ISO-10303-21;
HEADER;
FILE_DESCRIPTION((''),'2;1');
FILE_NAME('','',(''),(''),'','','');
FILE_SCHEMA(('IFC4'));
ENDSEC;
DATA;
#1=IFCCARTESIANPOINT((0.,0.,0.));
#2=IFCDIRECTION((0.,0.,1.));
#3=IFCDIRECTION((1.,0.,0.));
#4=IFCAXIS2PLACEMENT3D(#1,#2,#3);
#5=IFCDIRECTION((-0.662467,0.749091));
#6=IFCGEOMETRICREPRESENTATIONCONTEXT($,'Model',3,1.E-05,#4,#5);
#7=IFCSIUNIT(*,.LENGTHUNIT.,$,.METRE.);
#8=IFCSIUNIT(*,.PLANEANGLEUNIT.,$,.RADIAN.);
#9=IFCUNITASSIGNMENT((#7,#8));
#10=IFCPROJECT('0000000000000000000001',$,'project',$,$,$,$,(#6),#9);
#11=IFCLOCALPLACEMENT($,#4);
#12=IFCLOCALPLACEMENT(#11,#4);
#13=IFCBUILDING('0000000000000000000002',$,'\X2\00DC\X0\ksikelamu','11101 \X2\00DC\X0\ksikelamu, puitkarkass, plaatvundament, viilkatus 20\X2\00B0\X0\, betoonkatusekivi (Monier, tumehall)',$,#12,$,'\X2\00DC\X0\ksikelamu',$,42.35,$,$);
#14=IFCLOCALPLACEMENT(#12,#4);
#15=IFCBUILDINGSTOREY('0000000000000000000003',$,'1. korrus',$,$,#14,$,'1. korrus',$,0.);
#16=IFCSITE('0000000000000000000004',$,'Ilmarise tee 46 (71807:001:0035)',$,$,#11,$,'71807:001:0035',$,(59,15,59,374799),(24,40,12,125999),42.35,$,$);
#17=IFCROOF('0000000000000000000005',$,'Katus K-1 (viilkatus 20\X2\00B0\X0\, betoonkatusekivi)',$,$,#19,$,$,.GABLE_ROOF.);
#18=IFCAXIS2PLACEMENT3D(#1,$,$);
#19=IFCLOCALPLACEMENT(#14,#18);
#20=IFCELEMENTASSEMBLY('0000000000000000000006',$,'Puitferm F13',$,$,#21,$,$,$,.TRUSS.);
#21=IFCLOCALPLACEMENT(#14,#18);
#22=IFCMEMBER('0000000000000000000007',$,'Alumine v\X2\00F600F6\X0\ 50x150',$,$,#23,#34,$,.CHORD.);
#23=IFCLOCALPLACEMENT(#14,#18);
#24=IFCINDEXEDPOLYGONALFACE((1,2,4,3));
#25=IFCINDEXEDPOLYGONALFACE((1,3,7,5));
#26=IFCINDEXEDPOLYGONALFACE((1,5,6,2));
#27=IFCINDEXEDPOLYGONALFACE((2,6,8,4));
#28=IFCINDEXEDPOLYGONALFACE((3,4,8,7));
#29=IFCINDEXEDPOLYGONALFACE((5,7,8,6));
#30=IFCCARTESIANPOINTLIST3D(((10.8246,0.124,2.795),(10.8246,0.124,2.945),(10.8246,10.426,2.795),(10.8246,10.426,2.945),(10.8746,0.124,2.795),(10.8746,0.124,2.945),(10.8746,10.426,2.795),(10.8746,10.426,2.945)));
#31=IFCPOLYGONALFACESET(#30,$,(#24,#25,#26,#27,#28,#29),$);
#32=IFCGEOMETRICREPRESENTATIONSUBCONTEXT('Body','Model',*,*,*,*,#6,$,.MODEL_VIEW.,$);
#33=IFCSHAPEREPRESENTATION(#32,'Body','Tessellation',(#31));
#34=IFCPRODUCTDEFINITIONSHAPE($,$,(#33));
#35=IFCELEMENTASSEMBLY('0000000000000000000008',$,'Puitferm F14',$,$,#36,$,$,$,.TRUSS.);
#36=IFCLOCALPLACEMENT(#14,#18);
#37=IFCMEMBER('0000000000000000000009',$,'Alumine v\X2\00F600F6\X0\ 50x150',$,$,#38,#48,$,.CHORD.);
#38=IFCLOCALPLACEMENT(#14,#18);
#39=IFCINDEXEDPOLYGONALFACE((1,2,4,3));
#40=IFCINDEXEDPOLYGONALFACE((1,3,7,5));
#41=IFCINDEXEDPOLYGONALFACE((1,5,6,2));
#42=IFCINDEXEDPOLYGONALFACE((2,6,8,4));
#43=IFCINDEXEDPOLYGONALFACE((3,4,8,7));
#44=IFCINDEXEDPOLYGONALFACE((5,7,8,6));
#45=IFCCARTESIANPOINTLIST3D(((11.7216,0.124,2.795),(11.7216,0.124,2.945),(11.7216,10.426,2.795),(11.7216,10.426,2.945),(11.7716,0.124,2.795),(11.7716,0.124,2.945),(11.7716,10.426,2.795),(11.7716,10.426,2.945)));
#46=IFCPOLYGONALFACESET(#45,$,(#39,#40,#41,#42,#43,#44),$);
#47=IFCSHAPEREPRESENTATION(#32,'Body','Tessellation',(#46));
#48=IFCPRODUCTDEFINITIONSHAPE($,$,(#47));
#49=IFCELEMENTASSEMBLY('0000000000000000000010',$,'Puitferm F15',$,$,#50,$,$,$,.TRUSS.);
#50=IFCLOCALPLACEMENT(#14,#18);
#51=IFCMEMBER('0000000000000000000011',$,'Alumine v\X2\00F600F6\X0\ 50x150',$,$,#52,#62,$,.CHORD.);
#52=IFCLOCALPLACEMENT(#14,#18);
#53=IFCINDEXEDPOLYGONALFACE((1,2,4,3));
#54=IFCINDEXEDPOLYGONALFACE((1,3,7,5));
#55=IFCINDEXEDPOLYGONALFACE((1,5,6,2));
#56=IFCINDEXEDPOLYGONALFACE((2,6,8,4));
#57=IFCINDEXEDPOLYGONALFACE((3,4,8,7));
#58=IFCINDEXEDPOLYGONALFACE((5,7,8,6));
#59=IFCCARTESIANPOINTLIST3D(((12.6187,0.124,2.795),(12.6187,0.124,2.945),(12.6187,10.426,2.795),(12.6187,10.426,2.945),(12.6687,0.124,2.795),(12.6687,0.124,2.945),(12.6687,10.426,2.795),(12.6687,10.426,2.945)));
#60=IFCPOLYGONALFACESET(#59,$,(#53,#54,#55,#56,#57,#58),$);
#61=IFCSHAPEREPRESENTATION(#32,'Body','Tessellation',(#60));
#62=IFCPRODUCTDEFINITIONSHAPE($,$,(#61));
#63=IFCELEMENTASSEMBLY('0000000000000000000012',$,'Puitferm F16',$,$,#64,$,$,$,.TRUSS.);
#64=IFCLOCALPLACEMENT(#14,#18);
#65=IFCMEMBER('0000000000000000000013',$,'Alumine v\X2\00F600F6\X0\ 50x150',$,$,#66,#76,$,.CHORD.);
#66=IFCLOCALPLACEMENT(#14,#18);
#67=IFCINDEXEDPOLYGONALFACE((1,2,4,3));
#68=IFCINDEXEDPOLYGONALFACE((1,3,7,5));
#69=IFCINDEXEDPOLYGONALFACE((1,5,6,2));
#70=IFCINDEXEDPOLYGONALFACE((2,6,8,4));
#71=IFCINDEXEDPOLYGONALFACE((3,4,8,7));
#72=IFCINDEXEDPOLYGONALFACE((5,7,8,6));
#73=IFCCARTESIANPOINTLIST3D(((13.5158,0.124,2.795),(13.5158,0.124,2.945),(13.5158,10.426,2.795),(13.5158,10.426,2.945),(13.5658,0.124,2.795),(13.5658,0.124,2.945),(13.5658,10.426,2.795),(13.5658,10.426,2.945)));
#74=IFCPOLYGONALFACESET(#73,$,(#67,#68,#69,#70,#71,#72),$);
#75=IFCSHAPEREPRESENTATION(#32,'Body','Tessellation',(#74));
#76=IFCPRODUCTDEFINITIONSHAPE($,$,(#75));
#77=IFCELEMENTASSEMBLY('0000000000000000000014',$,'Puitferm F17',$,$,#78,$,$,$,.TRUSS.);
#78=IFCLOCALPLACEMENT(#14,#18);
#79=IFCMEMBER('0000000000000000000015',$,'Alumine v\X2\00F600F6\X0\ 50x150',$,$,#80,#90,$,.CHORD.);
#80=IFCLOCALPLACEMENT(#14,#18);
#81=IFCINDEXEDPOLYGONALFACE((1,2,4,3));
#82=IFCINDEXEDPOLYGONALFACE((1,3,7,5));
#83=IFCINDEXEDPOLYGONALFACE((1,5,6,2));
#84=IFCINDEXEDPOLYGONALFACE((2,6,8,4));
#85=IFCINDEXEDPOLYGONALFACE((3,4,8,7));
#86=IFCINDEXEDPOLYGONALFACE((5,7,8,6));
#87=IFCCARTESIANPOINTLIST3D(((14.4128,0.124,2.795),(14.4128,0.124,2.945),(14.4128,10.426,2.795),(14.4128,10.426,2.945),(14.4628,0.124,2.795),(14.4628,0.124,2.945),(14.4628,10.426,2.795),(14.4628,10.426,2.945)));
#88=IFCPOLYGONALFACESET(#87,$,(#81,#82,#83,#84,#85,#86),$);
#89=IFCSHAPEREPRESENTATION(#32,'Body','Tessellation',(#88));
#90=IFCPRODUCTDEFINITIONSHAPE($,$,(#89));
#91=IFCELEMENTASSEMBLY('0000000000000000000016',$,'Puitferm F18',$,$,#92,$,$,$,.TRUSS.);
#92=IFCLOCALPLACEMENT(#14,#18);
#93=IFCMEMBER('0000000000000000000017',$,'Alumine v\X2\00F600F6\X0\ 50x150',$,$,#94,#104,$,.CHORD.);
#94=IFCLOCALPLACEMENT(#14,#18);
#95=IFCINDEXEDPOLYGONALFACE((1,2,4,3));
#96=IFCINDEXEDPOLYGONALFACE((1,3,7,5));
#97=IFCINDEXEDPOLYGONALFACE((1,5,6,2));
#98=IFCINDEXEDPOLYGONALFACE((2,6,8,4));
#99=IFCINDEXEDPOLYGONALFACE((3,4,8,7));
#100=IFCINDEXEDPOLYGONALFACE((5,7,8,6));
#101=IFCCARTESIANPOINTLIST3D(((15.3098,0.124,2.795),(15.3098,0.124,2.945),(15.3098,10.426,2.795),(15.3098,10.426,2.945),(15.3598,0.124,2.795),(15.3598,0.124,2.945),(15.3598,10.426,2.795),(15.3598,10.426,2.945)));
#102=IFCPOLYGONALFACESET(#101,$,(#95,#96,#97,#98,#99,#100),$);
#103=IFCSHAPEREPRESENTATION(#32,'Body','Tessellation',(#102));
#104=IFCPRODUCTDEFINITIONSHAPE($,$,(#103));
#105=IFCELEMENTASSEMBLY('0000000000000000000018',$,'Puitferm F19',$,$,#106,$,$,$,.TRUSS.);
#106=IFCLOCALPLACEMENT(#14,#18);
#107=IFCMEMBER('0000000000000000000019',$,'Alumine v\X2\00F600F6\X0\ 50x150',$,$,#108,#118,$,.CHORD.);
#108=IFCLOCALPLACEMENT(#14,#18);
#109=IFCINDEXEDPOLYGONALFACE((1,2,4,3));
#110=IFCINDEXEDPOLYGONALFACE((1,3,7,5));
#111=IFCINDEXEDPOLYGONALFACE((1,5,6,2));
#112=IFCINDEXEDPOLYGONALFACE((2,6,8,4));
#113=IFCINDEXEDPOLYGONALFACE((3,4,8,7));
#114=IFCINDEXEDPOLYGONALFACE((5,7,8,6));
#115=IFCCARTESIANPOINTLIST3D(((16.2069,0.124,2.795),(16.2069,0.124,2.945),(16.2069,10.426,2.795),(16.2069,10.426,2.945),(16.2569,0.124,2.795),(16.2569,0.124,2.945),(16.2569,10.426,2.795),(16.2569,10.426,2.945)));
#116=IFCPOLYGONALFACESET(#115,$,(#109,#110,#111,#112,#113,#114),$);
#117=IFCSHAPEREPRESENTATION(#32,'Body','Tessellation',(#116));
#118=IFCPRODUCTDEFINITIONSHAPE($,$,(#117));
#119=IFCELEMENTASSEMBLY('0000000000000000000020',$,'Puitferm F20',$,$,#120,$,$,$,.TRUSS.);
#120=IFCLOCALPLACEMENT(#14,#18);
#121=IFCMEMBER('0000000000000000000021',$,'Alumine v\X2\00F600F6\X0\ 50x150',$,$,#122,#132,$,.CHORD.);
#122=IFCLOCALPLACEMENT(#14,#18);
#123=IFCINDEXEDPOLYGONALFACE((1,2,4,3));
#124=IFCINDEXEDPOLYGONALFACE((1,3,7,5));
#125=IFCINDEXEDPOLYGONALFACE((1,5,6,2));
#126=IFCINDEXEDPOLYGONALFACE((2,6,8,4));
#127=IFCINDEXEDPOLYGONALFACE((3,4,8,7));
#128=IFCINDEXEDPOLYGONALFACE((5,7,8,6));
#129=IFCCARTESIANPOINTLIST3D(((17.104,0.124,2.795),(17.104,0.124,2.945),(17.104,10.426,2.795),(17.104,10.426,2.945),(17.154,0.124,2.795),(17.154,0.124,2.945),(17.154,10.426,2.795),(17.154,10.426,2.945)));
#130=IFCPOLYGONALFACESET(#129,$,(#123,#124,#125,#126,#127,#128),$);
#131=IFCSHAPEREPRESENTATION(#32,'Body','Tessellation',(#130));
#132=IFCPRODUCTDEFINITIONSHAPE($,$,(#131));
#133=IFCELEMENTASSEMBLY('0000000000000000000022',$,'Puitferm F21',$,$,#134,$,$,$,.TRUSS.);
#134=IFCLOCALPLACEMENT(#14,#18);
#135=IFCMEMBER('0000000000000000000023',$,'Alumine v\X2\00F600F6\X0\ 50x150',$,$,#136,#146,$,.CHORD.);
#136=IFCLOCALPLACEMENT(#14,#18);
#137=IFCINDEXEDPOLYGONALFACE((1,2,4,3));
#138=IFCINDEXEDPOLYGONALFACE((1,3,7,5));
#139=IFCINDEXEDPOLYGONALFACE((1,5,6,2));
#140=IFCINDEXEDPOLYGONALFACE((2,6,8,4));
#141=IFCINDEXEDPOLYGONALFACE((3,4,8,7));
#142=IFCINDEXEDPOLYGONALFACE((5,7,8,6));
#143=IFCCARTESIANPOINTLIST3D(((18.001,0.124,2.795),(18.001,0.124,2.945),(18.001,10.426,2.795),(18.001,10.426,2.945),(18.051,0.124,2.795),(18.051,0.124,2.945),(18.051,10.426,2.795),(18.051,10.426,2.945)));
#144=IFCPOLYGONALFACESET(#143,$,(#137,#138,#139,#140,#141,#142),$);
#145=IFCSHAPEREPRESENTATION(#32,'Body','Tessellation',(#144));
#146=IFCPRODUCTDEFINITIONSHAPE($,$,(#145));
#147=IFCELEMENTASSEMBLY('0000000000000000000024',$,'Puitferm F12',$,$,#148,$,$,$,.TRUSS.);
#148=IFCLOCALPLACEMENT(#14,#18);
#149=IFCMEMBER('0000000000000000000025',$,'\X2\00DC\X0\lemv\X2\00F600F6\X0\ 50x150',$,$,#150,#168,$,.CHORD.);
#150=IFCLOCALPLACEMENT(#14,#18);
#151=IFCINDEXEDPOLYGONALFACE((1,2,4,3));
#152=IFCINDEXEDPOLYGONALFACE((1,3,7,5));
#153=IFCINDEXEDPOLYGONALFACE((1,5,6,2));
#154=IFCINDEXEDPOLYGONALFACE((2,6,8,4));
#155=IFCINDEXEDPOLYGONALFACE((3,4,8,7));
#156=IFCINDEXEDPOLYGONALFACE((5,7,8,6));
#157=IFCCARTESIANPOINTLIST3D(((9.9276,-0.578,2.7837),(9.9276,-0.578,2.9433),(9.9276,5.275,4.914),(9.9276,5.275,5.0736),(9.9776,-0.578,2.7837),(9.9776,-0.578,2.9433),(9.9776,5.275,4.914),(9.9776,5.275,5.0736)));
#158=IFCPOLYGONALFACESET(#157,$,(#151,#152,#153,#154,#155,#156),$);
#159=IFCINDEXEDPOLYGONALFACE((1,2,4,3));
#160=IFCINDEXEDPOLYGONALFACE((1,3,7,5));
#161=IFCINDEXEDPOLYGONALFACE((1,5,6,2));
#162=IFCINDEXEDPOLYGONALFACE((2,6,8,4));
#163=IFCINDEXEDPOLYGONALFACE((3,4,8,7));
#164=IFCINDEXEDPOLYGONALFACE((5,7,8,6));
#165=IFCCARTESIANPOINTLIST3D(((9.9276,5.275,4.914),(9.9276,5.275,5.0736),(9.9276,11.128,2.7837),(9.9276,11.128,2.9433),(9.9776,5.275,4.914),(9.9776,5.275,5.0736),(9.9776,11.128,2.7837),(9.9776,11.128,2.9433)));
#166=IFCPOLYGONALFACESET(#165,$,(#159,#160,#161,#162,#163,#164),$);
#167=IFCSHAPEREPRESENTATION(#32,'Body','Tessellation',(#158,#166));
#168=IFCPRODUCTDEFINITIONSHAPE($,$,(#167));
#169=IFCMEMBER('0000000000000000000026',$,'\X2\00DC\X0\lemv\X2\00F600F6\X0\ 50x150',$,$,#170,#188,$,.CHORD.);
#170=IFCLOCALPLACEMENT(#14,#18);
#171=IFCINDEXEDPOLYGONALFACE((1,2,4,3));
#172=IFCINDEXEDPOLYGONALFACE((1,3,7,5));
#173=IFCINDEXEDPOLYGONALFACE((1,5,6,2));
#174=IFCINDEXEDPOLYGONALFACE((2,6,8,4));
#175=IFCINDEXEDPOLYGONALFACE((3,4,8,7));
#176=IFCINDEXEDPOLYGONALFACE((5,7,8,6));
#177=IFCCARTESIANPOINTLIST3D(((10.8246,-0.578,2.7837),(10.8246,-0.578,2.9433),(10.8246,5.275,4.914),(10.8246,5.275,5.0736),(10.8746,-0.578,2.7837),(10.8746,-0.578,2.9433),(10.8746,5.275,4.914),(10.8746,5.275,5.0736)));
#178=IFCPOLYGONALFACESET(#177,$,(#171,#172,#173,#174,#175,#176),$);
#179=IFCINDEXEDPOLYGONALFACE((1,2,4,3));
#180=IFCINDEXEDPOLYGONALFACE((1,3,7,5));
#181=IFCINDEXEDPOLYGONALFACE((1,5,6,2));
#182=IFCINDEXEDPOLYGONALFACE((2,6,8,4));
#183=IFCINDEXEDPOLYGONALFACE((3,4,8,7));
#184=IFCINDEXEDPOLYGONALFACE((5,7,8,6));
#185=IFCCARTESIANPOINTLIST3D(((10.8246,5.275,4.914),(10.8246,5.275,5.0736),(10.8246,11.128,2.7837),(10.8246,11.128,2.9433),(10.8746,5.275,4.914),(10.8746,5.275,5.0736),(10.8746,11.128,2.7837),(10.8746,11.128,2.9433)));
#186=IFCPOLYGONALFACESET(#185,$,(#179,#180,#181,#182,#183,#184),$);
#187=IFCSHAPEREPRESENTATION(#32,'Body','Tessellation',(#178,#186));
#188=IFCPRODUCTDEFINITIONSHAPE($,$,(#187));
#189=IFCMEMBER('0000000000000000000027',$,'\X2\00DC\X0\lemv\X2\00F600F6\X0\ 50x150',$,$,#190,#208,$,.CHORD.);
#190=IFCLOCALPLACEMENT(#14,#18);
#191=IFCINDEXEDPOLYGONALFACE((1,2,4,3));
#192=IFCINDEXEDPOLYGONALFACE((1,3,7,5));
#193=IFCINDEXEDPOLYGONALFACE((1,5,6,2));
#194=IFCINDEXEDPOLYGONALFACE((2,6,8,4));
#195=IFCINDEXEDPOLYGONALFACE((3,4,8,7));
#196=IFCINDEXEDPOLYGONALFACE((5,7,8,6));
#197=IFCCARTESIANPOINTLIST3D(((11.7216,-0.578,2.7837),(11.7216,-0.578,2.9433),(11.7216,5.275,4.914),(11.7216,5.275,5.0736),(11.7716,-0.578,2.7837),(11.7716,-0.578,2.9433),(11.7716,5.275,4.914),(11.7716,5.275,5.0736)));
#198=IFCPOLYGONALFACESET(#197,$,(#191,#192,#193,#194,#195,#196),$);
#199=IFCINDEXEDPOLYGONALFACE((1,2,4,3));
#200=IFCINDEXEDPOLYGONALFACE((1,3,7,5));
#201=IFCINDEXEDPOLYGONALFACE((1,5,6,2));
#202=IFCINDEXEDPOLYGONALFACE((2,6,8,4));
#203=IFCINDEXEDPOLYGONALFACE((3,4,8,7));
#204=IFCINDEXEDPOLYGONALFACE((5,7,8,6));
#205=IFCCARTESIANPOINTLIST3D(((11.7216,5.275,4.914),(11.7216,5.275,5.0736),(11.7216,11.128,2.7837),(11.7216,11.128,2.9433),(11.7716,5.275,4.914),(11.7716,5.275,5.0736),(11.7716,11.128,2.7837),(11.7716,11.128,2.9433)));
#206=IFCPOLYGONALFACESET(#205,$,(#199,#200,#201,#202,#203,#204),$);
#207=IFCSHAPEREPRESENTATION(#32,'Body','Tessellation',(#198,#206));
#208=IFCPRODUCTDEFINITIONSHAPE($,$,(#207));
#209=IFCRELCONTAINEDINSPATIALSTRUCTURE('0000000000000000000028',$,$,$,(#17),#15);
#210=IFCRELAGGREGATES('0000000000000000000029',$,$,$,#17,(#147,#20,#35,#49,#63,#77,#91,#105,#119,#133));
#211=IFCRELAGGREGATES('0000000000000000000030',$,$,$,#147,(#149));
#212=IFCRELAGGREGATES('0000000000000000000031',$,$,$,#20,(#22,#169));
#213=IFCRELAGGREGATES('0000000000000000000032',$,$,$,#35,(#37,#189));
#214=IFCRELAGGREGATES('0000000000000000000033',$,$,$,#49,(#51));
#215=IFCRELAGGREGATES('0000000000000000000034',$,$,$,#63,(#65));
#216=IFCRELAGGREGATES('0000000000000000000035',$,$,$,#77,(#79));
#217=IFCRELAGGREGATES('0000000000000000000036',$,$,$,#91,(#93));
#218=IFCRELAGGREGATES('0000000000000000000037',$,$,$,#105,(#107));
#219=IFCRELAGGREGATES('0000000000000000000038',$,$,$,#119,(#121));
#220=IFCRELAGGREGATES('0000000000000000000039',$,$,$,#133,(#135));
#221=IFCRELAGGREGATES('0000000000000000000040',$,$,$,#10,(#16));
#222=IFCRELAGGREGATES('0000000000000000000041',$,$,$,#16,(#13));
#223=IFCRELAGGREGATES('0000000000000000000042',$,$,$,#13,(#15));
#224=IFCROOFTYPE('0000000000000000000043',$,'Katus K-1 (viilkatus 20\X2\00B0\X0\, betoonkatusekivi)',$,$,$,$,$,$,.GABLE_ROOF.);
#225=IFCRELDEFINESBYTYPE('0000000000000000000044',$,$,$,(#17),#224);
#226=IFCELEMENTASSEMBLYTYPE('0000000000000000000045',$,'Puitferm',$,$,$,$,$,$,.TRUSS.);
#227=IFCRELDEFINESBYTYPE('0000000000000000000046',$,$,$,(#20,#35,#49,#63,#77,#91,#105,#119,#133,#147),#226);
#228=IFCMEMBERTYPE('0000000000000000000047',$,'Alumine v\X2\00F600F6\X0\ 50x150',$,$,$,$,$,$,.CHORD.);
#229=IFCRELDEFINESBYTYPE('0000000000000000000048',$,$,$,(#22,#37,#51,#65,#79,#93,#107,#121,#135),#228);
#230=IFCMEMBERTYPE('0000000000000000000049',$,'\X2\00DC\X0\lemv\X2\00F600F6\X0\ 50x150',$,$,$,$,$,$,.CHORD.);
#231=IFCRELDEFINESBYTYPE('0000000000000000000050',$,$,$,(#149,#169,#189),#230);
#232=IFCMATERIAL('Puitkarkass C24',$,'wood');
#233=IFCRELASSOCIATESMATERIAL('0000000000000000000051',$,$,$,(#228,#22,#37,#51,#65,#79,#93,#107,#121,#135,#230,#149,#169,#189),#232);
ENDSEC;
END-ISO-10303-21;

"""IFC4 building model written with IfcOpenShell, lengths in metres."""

from ifc_helpers import new_model, si_unit, direction, frame, origin_with_axes, place, context, subcontext, project, spatial, indexed_curve, outline, extrude, material, type_object, element, aggregate, save


model = new_model("IFC4")

# Units and contexts
model_context = context("Model", 3, precision=1e-05, world=origin_with_axes(), true_north=direction((-0.662467, 0.749091)))
body_context = subcontext(model_context, "Body", "Model", "MODEL_VIEW")
ifc_project = project(units=[si_unit("LENGTHUNIT", "METRE"), si_unit("PLANEANGLEUNIT", "RADIAN")], contexts=[model_context])

# Site, building, storey
site_placement = place(None, origin_with_axes())
site = spatial("IfcSite", under=ifc_project, at=site_placement, Name="Ilmarise tee 46 (71807:001:0035)", LongName="71807:001:0035", RefLatitude=(59, 15, 59, 374799), RefLongitude=(24, 40, 12, 125999), RefElevation=42.35)
building_placement = place(site_placement, origin_with_axes())
building = spatial("IfcBuilding", under=site, at=building_placement, Name="Üksikelamu", Description="11101 Üksikelamu, puitkarkass, plaatvundament, viilkatus 20°, betoonkatusekivi (Monier, tumehall)", LongName="Üksikelamu", ElevationOfRefHeight=42.35)
storey_placement = place(building_placement, origin_with_axes())
storey = spatial("IfcBuildingStorey", under=building, at=storey_placement, Name="1. korrus", LongName="1. korrus", Elevation=0.0)

# Roof, element assemblies, members
roof_type = type_object("IfcRoofType", Name="Katus K-1 (viilkatus 20°, betoonkatusekivi)", PredefinedType="GABLE_ROOF")
roof_placement = place(storey_placement, origin_with_axes())
roof = element("IfcRoof", 1, at=roof_placement, inside=storey, type_object=roof_type, Name="Katus K-1 (viilkatus 20°, betoonkatusekivi)", PredefinedType="GABLE_ROOF")
element_assembly_type = type_object("IfcElementAssemblyType", Name="Puitferm", PredefinedType="TRUSS")
assembly_1_placement = place(roof_placement, origin_with_axes())
assembly_1 = element("IfcElementAssembly", 2, at=assembly_1_placement, type_object=element_assembly_type, Name="Puitferm F13", PredefinedType="TRUSS")
ifc_material = material(Name="Puitkarkass C24", Category="wood")
member_type_1 = type_object("IfcMemberType", Name="Alumine vöö 50x150", PredefinedType="CHORD", material=ifc_material)
member_1_placement = place(assembly_1_placement, origin_with_axes())
member_1 = element("IfcMember", 3, at=member_1_placement, type_object=member_type_1, material=ifc_material, Name="Alumine vöö 50x150", PredefinedType="CHORD", context=body_context, shape_type="SweptSolid", body=[
    extrude(outline(indexed_curve([(0.124, 2.795), (10.426, 2.795), (10.426, 2.945), (0.124, 2.945), (0.124, 2.795)], self_intersect=False)), frame((10.8246, 0.0, 0.0), z_axis=(1.0, 0.0, 0.0), x_axis=(0.0, 1.0, 0.0)), (0.0, 0.0, 1.0), 0.05),
])
assembly_2_placement = place(roof_placement, origin_with_axes())
assembly_2 = element("IfcElementAssembly", 4, at=assembly_2_placement, type_object=element_assembly_type, Name="Puitferm F14", PredefinedType="TRUSS")
member_2_placement = place(assembly_2_placement, origin_with_axes())
member_2 = element("IfcMember", 5, at=member_2_placement, type_object=member_type_1, material=ifc_material, Name="Alumine vöö 50x150", PredefinedType="CHORD", context=body_context, shape_type="SweptSolid", body=[
    extrude(outline(indexed_curve([(0.124, 2.795), (10.426, 2.795), (10.426, 2.945), (0.124, 2.945), (0.124, 2.795)], self_intersect=False)), frame((11.7216, 0.0, 0.0), z_axis=(1.0, 0.0, 0.0), x_axis=(0.0, 1.0, 0.0)), (0.0, 0.0, 1.0), 0.05),
])
assembly_3_placement = place(roof_placement, origin_with_axes())
assembly_3 = element("IfcElementAssembly", 6, at=assembly_3_placement, type_object=element_assembly_type, Name="Puitferm F15", PredefinedType="TRUSS")
member_3_placement = place(assembly_3_placement, origin_with_axes())
member_3 = element("IfcMember", 7, at=member_3_placement, type_object=member_type_1, material=ifc_material, Name="Alumine vöö 50x150", PredefinedType="CHORD", context=body_context, shape_type="SweptSolid", body=[
    extrude(outline(indexed_curve([(0.124, 2.795), (10.426, 2.795), (10.426, 2.945), (0.124, 2.945), (0.124, 2.795)], self_intersect=False)), frame((12.6187, 0.0, 0.0), z_axis=(1.0, 0.0, 0.0), x_axis=(0.0, 1.0, 0.0)), (0.0, 0.0, 1.0), 0.05),
])
assembly_4_placement = place(roof_placement, origin_with_axes())
assembly_4 = element("IfcElementAssembly", 8, at=assembly_4_placement, type_object=element_assembly_type, Name="Puitferm F16", PredefinedType="TRUSS")
member_4_placement = place(assembly_4_placement, origin_with_axes())
member_4 = element("IfcMember", 9, at=member_4_placement, type_object=member_type_1, material=ifc_material, Name="Alumine vöö 50x150", PredefinedType="CHORD", context=body_context, shape_type="SweptSolid", body=[
    extrude(outline(indexed_curve([(0.124, 2.795), (10.426, 2.795), (10.426, 2.945), (0.124, 2.945), (0.124, 2.795)], self_intersect=False)), frame((13.5158, 0.0, 0.0), z_axis=(1.0, 0.0, 0.0), x_axis=(0.0, 1.0, 0.0)), (0.0, 0.0, 1.0), 0.05),
])
assembly_5_placement = place(roof_placement, origin_with_axes())
assembly_5 = element("IfcElementAssembly", 10, at=assembly_5_placement, type_object=element_assembly_type, Name="Puitferm F17", PredefinedType="TRUSS")
member_5_placement = place(assembly_5_placement, origin_with_axes())
member_5 = element("IfcMember", 11, at=member_5_placement, type_object=member_type_1, material=ifc_material, Name="Alumine vöö 50x150", PredefinedType="CHORD", context=body_context, shape_type="SweptSolid", body=[
    extrude(outline(indexed_curve([(0.124, 2.795), (10.426, 2.795), (10.426, 2.945), (0.124, 2.945), (0.124, 2.795)], self_intersect=False)), frame((14.4128, 0.0, 0.0), z_axis=(1.0, 0.0, 0.0), x_axis=(0.0, 1.0, 0.0)), (0.0, 0.0, 1.0), 0.05),
])
assembly_6_placement = place(roof_placement, origin_with_axes())
assembly_6 = element("IfcElementAssembly", 12, at=assembly_6_placement, type_object=element_assembly_type, Name="Puitferm F18", PredefinedType="TRUSS")
member_6_placement = place(assembly_6_placement, origin_with_axes())
member_6 = element("IfcMember", 13, at=member_6_placement, type_object=member_type_1, material=ifc_material, Name="Alumine vöö 50x150", PredefinedType="CHORD", context=body_context, shape_type="SweptSolid", body=[
    extrude(outline(indexed_curve([(0.124, 2.795), (10.426, 2.795), (10.426, 2.945), (0.124, 2.945), (0.124, 2.795)], self_intersect=False)), frame((15.3098, 0.0, 0.0), z_axis=(1.0, 0.0, 0.0), x_axis=(0.0, 1.0, 0.0)), (0.0, 0.0, 1.0), 0.05),
])
assembly_7_placement = place(roof_placement, origin_with_axes())
assembly_7 = element("IfcElementAssembly", 14, at=assembly_7_placement, type_object=element_assembly_type, Name="Puitferm F19", PredefinedType="TRUSS")
member_7_placement = place(assembly_7_placement, origin_with_axes())
member_7 = element("IfcMember", 15, at=member_7_placement, type_object=member_type_1, material=ifc_material, Name="Alumine vöö 50x150", PredefinedType="CHORD", context=body_context, shape_type="SweptSolid", body=[
    extrude(outline(indexed_curve([(0.124, 2.795), (10.426, 2.795), (10.426, 2.945), (0.124, 2.945), (0.124, 2.795)], self_intersect=False)), frame((16.2069, 0.0, 0.0), z_axis=(1.0, 0.0, 0.0), x_axis=(0.0, 1.0, 0.0)), (0.0, 0.0, 1.0), 0.05),
])
assembly_8_placement = place(roof_placement, origin_with_axes())
assembly_8 = element("IfcElementAssembly", 16, at=assembly_8_placement, type_object=element_assembly_type, Name="Puitferm F20", PredefinedType="TRUSS")
member_8_placement = place(assembly_8_placement, origin_with_axes())
member_8 = element("IfcMember", 17, at=member_8_placement, type_object=member_type_1, material=ifc_material, Name="Alumine vöö 50x150", PredefinedType="CHORD", context=body_context, shape_type="SweptSolid", body=[
    extrude(outline(indexed_curve([(0.124, 2.795), (10.426, 2.795), (10.426, 2.945), (0.124, 2.945), (0.124, 2.795)], self_intersect=False)), frame((17.104, 0.0, 0.0), z_axis=(1.0, 0.0, 0.0), x_axis=(0.0, 1.0, 0.0)), (0.0, 0.0, 1.0), 0.05),
])
assembly_9_placement = place(roof_placement, origin_with_axes())
assembly_9 = element("IfcElementAssembly", 18, at=assembly_9_placement, type_object=element_assembly_type, Name="Puitferm F21", PredefinedType="TRUSS")
member_9_placement = place(assembly_9_placement, origin_with_axes())
member_9 = element("IfcMember", 19, at=member_9_placement, type_object=member_type_1, material=ifc_material, Name="Alumine vöö 50x150", PredefinedType="CHORD", context=body_context, shape_type="SweptSolid", body=[
    extrude(outline(indexed_curve([(0.124, 2.795), (10.426, 2.795), (10.426, 2.945), (0.124, 2.945), (0.124, 2.795)], self_intersect=False)), frame((18.001, 0.0, 0.0), z_axis=(1.0, 0.0, 0.0), x_axis=(0.0, 1.0, 0.0)), (0.0, 0.0, 1.0), 0.05),
])
assembly_10_placement = place(roof_placement, origin_with_axes())
assembly_10 = element("IfcElementAssembly", 20, at=assembly_10_placement, type_object=element_assembly_type, Name="Puitferm F12", PredefinedType="TRUSS")
aggregate(roof, [assembly_10, assembly_1, assembly_2, assembly_3, assembly_4, assembly_5, assembly_6, assembly_7, assembly_8, assembly_9])
member_type_2 = type_object("IfcMemberType", Name="Ülemvöö 50x150", PredefinedType="CHORD", material=ifc_material)
member_10_placement = place(assembly_10_placement, origin_with_axes())
member_10 = element("IfcMember", 21, at=member_10_placement, type_object=member_type_2, material=ifc_material, Name="Ülemvöö 50x150", PredefinedType="CHORD", context=body_context, shape_type="SweptSolid", body=[
    extrude(outline(indexed_curve([(-0.578, 2.7837), (5.275, 4.914), (5.275, 5.0736), (-0.578, 2.9433), (-0.578, 2.7837)], self_intersect=False)), frame((9.9276, 0.0, 0.0), z_axis=(1.0, 0.0, 0.0), x_axis=(0.0, 1.0, 0.0)), (0.0, 0.0, 1.0), 0.05),
    extrude(outline(indexed_curve([(5.275, 4.914), (11.128, 2.7837), (11.128, 2.9433), (5.275, 5.0736), (5.275, 4.914)], self_intersect=False)), frame((9.9276, 0.0, 0.0), z_axis=(1.0, 0.0, 0.0), x_axis=(0.0, 1.0, 0.0)), (0.0, 0.0, 1.0), 0.05),
])
member_11_placement = place(assembly_1_placement, origin_with_axes())
member_11 = element("IfcMember", 22, at=member_11_placement, type_object=member_type_2, material=ifc_material, Name="Ülemvöö 50x150", PredefinedType="CHORD", context=body_context, shape_type="SweptSolid", body=[
    extrude(outline(indexed_curve([(-0.578, 2.7837), (5.275, 4.914), (5.275, 5.0736), (-0.578, 2.9433), (-0.578, 2.7837)], self_intersect=False)), frame((10.8246, 0.0, 0.0), z_axis=(1.0, 0.0, 0.0), x_axis=(0.0, 1.0, 0.0)), (0.0, 0.0, 1.0), 0.05),
    extrude(outline(indexed_curve([(5.275, 4.914), (11.128, 2.7837), (11.128, 2.9433), (5.275, 5.0736), (5.275, 4.914)], self_intersect=False)), frame((10.8246, 0.0, 0.0), z_axis=(1.0, 0.0, 0.0), x_axis=(0.0, 1.0, 0.0)), (0.0, 0.0, 1.0), 0.05),
])
member_12_placement = place(assembly_2_placement, origin_with_axes())
member_12 = element("IfcMember", 23, at=member_12_placement, type_object=member_type_2, material=ifc_material, Name="Ülemvöö 50x150", PredefinedType="CHORD", context=body_context, shape_type="SweptSolid", body=[
    extrude(outline(indexed_curve([(-0.578, 2.7837), (5.275, 4.914), (5.275, 5.0736), (-0.578, 2.9433), (-0.578, 2.7837)], self_intersect=False)), frame((11.7216, 0.0, 0.0), z_axis=(1.0, 0.0, 0.0), x_axis=(0.0, 1.0, 0.0)), (0.0, 0.0, 1.0), 0.05),
    extrude(outline(indexed_curve([(5.275, 4.914), (11.128, 2.7837), (11.128, 2.9433), (5.275, 5.0736), (5.275, 4.914)], self_intersect=False)), frame((11.7216, 0.0, 0.0), z_axis=(1.0, 0.0, 0.0), x_axis=(0.0, 1.0, 0.0)), (0.0, 0.0, 1.0), 0.05),
])
aggregate(assembly_10, [member_10])
aggregate(assembly_1, [member_1, member_11])
aggregate(assembly_2, [member_2, member_12])
aggregate(assembly_3, [member_3])
aggregate(assembly_4, [member_4])
aggregate(assembly_5, [member_5])
aggregate(assembly_6, [member_6])
aggregate(assembly_7, [member_7])
aggregate(assembly_8, [member_8])
aggregate(assembly_9, [member_9])

save(model, "model.ifc")
